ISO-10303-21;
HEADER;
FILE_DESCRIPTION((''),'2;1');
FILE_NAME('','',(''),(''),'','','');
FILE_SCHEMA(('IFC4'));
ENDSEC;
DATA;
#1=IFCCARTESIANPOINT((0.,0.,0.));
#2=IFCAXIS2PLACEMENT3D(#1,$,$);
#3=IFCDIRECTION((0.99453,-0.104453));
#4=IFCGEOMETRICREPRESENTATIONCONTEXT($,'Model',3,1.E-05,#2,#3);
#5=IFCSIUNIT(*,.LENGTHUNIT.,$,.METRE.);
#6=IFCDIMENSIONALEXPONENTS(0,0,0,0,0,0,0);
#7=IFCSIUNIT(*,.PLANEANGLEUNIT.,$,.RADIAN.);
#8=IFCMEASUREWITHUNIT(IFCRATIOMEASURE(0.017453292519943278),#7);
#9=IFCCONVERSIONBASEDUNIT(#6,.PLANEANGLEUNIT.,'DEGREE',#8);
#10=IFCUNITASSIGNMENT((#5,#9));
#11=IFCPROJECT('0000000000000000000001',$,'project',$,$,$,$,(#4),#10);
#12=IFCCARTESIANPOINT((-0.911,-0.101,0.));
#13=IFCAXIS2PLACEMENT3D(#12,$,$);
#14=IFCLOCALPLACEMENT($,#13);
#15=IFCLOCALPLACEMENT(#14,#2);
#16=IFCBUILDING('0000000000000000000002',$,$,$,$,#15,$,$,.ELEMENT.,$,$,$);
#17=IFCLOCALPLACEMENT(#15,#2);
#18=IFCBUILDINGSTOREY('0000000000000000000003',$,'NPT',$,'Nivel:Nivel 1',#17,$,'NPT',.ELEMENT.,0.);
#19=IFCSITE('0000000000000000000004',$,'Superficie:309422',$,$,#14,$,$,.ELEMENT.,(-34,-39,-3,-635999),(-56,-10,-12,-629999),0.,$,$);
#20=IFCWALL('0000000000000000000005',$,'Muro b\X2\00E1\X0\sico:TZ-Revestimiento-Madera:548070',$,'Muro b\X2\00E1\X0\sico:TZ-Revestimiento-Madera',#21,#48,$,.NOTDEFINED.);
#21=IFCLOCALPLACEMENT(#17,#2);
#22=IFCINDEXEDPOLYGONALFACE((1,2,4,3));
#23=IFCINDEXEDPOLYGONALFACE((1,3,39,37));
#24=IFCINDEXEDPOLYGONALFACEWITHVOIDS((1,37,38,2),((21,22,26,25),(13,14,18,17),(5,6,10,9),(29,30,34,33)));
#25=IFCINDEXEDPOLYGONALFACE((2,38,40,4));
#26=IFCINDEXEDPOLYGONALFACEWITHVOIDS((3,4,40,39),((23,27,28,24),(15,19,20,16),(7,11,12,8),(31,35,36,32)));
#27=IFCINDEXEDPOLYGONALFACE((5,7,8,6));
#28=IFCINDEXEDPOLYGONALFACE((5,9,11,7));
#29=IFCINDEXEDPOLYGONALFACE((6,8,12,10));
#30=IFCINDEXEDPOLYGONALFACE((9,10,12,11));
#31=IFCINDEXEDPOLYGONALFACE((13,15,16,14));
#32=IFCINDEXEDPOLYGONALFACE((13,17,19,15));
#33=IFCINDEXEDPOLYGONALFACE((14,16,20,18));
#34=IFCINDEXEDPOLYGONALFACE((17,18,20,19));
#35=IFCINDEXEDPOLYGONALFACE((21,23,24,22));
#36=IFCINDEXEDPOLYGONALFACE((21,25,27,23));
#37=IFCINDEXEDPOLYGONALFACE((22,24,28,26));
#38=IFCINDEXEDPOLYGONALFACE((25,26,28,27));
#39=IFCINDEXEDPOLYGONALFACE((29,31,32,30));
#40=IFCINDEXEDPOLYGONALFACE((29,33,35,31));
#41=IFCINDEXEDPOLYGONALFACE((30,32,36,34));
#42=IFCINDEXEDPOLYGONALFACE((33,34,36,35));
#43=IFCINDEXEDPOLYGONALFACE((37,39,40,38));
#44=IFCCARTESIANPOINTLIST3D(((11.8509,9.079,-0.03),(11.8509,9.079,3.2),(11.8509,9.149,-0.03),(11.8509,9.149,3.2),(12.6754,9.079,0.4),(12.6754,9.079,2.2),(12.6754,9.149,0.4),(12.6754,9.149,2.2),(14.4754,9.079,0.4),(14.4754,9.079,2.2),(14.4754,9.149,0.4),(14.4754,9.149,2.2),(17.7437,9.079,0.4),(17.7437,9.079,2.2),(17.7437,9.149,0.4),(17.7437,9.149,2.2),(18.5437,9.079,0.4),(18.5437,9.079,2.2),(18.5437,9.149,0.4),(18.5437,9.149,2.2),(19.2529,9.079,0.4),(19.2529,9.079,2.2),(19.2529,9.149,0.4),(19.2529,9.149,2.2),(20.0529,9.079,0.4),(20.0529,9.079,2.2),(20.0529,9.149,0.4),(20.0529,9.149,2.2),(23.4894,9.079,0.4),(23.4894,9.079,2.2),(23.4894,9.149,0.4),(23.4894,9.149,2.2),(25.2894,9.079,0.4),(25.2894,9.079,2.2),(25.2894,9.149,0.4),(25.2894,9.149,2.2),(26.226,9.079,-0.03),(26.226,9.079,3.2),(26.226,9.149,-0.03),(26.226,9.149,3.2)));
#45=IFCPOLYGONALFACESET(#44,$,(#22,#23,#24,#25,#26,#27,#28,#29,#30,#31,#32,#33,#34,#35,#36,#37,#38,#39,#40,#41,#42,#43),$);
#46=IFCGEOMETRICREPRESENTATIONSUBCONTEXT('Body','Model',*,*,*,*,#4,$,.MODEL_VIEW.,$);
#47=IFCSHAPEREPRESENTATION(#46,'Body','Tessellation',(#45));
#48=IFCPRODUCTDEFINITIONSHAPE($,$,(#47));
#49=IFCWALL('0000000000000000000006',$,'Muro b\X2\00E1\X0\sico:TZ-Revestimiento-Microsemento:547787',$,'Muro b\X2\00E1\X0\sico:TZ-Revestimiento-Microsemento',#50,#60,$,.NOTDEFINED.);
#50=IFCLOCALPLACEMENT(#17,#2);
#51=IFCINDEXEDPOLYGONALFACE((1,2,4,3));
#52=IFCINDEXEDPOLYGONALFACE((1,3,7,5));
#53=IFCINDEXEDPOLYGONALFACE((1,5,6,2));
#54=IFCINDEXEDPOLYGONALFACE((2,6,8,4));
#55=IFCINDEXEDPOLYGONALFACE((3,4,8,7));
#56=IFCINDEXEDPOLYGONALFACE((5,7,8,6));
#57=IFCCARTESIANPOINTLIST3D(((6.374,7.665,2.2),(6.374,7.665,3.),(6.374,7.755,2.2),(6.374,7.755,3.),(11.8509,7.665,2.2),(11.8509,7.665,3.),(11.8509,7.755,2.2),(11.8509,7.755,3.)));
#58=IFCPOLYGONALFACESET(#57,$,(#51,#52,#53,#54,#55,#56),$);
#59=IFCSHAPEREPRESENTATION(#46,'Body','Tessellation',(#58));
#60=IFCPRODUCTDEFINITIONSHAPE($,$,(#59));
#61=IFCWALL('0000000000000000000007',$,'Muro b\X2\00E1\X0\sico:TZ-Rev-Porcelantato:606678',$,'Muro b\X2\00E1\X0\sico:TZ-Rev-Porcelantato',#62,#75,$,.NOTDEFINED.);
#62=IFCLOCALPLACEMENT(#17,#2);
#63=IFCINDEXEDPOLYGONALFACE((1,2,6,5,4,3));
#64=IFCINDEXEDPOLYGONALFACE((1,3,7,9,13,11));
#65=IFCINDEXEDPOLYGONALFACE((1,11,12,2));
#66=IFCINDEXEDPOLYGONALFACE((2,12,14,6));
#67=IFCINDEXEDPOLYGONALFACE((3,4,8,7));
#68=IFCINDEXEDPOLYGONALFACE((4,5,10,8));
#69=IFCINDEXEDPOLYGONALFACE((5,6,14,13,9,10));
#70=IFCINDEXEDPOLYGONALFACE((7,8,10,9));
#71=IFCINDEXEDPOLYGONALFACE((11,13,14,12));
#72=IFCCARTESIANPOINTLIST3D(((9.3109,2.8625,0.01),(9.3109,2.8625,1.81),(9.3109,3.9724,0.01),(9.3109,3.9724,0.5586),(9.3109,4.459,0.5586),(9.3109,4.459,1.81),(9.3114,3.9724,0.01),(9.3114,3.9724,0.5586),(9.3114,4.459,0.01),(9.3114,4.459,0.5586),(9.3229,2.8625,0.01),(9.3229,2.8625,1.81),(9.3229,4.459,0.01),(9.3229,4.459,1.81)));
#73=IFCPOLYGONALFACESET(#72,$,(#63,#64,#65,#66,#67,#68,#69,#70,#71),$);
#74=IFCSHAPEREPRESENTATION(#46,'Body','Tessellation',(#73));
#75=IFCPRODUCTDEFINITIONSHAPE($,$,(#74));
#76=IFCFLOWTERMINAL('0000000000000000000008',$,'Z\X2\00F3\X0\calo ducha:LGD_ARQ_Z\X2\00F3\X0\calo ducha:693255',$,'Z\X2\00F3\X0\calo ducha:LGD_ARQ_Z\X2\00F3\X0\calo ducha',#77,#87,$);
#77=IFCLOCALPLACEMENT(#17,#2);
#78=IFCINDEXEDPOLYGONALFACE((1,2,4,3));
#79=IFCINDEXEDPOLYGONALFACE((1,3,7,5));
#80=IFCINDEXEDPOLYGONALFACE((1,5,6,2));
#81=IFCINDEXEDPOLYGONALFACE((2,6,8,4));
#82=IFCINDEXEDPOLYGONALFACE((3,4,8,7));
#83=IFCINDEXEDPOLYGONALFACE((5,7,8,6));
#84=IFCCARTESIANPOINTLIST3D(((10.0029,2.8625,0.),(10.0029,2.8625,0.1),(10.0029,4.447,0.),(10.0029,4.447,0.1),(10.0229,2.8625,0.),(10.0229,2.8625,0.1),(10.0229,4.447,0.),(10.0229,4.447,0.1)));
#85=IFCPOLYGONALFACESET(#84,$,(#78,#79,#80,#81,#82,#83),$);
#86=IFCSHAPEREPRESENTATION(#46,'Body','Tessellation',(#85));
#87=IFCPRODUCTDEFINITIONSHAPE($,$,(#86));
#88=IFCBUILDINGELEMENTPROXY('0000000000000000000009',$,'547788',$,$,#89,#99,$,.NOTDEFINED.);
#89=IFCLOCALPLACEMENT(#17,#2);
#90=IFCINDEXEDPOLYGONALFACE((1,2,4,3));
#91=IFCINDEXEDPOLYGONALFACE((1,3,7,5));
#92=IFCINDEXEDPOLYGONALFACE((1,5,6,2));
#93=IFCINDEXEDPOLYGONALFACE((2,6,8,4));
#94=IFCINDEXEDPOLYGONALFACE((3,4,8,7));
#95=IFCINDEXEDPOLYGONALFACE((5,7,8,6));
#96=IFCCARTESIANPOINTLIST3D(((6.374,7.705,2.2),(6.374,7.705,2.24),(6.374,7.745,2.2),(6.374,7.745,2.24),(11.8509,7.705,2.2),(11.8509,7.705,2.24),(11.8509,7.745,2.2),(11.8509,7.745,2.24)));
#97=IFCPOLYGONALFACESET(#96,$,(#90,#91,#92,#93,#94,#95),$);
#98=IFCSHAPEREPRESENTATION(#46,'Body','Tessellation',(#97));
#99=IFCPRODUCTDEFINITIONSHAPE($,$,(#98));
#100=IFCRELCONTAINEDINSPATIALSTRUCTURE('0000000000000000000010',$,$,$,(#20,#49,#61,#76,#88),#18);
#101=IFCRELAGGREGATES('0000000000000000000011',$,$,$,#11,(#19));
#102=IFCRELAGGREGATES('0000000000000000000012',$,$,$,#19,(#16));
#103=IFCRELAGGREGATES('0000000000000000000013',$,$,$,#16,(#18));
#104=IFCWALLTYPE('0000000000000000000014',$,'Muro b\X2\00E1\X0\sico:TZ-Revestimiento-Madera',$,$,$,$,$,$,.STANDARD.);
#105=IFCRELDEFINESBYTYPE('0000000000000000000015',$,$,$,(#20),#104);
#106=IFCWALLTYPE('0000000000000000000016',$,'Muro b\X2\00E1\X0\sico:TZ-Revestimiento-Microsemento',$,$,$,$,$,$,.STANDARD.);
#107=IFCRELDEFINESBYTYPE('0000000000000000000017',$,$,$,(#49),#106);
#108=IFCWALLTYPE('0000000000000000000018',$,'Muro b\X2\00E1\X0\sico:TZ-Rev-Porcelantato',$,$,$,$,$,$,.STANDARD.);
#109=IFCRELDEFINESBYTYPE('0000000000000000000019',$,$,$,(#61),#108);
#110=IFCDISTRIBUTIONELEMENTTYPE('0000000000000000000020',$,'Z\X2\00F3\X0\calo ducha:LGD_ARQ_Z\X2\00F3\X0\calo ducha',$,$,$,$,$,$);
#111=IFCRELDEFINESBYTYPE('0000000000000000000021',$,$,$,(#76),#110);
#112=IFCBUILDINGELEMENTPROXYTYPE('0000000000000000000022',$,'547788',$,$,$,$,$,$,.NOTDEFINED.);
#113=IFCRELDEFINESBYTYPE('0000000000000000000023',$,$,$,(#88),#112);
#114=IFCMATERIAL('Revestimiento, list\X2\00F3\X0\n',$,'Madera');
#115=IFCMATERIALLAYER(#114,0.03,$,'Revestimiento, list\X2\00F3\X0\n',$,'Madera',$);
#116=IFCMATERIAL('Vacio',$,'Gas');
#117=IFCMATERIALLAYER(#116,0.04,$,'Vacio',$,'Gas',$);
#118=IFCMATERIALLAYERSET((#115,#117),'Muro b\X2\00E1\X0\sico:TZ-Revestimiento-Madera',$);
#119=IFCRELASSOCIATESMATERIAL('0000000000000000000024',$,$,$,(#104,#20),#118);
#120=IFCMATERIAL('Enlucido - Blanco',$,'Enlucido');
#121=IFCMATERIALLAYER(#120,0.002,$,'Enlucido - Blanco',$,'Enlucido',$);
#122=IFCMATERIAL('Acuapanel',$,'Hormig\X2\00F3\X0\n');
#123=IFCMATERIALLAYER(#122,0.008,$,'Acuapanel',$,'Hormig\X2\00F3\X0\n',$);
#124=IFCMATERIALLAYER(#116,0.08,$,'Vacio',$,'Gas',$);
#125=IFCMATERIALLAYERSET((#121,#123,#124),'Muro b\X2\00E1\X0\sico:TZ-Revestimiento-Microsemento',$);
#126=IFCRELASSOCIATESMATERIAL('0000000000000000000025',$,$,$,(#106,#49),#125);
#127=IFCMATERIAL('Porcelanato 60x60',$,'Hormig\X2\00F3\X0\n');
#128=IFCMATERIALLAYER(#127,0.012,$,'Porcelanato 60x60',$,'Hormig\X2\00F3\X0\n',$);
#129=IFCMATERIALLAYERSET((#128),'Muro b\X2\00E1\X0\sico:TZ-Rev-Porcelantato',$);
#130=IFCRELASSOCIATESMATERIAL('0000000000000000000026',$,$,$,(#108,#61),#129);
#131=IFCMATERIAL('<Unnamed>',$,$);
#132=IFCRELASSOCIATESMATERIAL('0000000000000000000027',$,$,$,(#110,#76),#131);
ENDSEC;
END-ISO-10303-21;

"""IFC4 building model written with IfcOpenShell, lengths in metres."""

from ifc_helpers import new_model, entity, si_unit, converted_unit, direction, frame, frame_2d, origin, origin_2d_with_axis, place, context, subcontext, project, spatial, polyline, rectangle, extrude, clip, bounded_halfspace, source, transform, mapped, material, layer, layer_set, layer_usage, type_object, type_shapes, element, save


model = new_model("IFC4")

# Units and contexts
model_context = context("Model", 3, precision=1e-05, world=origin(), true_north=direction((0.99453, -0.104453)))
body_context = subcontext(model_context, "Body", "Model", "MODEL_VIEW")
ifc_project = project(units=[si_unit("LENGTHUNIT", "METRE"), converted_unit("PLANEANGLEUNIT", "DEGREE", entity("IfcRatioMeasure", 0.017453292519943278), si_unit("PLANEANGLEUNIT", "RADIAN"), dimensions=[0, 0, 0, 0, 0, 0, 0])], contexts=[model_context])

# Site, building, storey
site_placement = place(None, frame((-0.911, -0.101, 0.0)))
site = spatial("IfcSite", under=ifc_project, at=site_placement, Name="Superficie:309422", CompositionType="ELEMENT", RefLatitude=(-34, -39, -3, -635999), RefLongitude=(-56, -10, -12, -629999), RefElevation=0.0)
building_placement = place(site_placement, origin())
building = spatial("IfcBuilding", under=site, at=building_placement, CompositionType="ELEMENT")
storey_placement = place(building_placement, origin())
storey = spatial("IfcBuildingStorey", under=building, at=storey_placement, Name="NPT", ObjectType="Nivel:Nivel 1", LongName="NPT", CompositionType="ELEMENT", Elevation=0.0)

# Shared definitions
ifc_material_1 = material(Name="<Unnamed>")

# Wall, openings
ifc_material_2 = material(Name="Revestimiento, listón", Category="Madera")
ifc_layer_1 = layer(ifc_material_2, 0.03, Name="Revestimiento, listón", Category="Madera")
ifc_material_3 = material(Name="Vacio", Category="Gas")
ifc_layer_2 = layer(ifc_material_3, 0.04, Name="Vacio", Category="Gas")
ifc_layer_set_1 = layer_set([ifc_layer_1, ifc_layer_2], Name="Muro básico:TZ-Revestimiento-Madera")
ifc_layer_usage_1 = layer_usage(ifc_layer_set_1, "AXIS2", "NEGATIVE", 0.035)
wall_type_1 = type_object("IfcWallType", Name="Muro básico:TZ-Revestimiento-Madera", PredefinedType="STANDARD", material=ifc_layer_set_1)
wall_1_placement = place(storey_placement, frame((11.8509, 9.114, -0.03)))
wall_1 = element("IfcWall", 1, at=wall_1_placement, inside=storey, type_object=wall_type_1, material=ifc_layer_usage_1, Name="Muro básico:TZ-Revestimiento-Madera:548070", ObjectType="Muro básico:TZ-Revestimiento-Madera", PredefinedType="NOTDEFINED", context=body_context, shape_type="SweptSolid", body=[
    extrude(rectangle(XDim=14.375, YDim=0.07, at=frame_2d((7.1875, 0.0), x_axis=(1.0, 0.0))), origin(), (0.0, 0.0, 1.0), 3.23),
])
opening_1_placement = place(wall_1_placement, frame((5.8928, -1.676, 0.43)))
element("IfcOpeningElement", 2, at=opening_1_placement, cuts=wall_1, PredefinedType="OPENING", context=body_context, shape_type="SweptSolid", body=[
    extrude(rectangle(XDim=1.8, YDim=0.8, at=frame_2d((0.0, 0.0), x_axis=(1.0, 0.0))), frame((0.4, 0.0, 0.9), z_axis=(0.0, 1.0, 0.0), x_axis=(0.0, 0.0, 1.0)), (0.0, 0.0, 1.0), 3.048),
])
opening_2_placement = place(wall_1_placement, frame((0.8245, -1.676, 0.43)))
element("IfcOpeningElement", 3, at=opening_2_placement, cuts=wall_1, PredefinedType="OPENING", context=body_context, shape_type="SweptSolid", body=[
    extrude(rectangle(XDim=1.8, YDim=1.8, at=origin_2d_with_axis()), frame((0.9, 0.0, 0.9), z_axis=(0.0, 1.0, 0.0), x_axis=(0.0, 0.0, 1.0)), (0.0, 0.0, 1.0), 3.048),
])
opening_3_placement = place(wall_1_placement, frame((11.6385, -1.676, 0.43)))
element("IfcOpeningElement", 4, at=opening_3_placement, cuts=wall_1, PredefinedType="OPENING", context=body_context, shape_type="SweptSolid", body=[
    extrude(rectangle(XDim=1.8, YDim=1.8, at=frame_2d((0.0, 0.0), x_axis=(0.0, 1.0))), frame((0.9, 0.0, 0.9), z_axis=(0.0, 1.0, 0.0), x_axis=(-1.0, 0.0, 0.0)), (0.0, 0.0, 1.0), 3.048),
])
opening_4_placement = place(wall_1_placement, frame((7.402, -1.676, 0.43)))
element("IfcOpeningElement", 5, at=opening_4_placement, cuts=wall_1, PredefinedType="OPENING", context=body_context, shape_type="SweptSolid", body=[
    extrude(rectangle(XDim=1.8, YDim=0.8, at=frame_2d((0.0, 0.0), x_axis=(1.0, 0.0))), frame((0.4, 0.0, 0.9), z_axis=(0.0, 1.0, 0.0), x_axis=(0.0, 0.0, 1.0)), (0.0, 0.0, 1.0), 3.048),
])

# Wall
ifc_material_4 = material(Name="Enlucido - Blanco", Category="Enlucido")
ifc_layer_3 = layer(ifc_material_4, 0.002, Name="Enlucido - Blanco", Category="Enlucido")
ifc_material_5 = material(Name="Acuapanel", Category="Hormigón")
ifc_layer_4 = layer(ifc_material_5, 0.008, Name="Acuapanel", Category="Hormigón")
ifc_layer_5 = layer(ifc_material_3, 0.08, Name="Vacio", Category="Gas")
ifc_layer_set_2 = layer_set([ifc_layer_3, ifc_layer_4, ifc_layer_5], Name="Muro básico:TZ-Revestimiento-Microsemento")
ifc_layer_usage_2 = layer_usage(ifc_layer_set_2, "AXIS2", "NEGATIVE", 0.045)
wall_type_2 = type_object("IfcWallType", Name="Muro básico:TZ-Revestimiento-Microsemento", PredefinedType="STANDARD", material=ifc_layer_set_2)
wall_2_placement = place(storey_placement, frame((6.374, 7.71, 2.2)))
element("IfcWall", 6, at=wall_2_placement, inside=storey, type_object=wall_type_2, material=ifc_layer_usage_2, Name="Muro básico:TZ-Revestimiento-Microsemento:547787", ObjectType="Muro básico:TZ-Revestimiento-Microsemento", PredefinedType="NOTDEFINED", context=body_context, shape_type="SweptSolid", body=[
    extrude(rectangle(XDim=5.4769, YDim=0.09, at=frame_2d((2.7385, 0.0), x_axis=(-1.0, 0.0))), origin(), (0.0, 0.0, 1.0), 0.8),
])

# Wall
ifc_material_6 = material(Name="Porcelanato 60x60", Category="Hormigón")
ifc_layer_6 = layer(ifc_material_6, 0.012, Name="Porcelanato 60x60", Category="Hormigón")
ifc_layer_set_3 = layer_set([ifc_layer_6], Name="Muro básico:TZ-Rev-Porcelantato")
ifc_layer_usage_3 = layer_usage(ifc_layer_set_3, "AXIS2", "POSITIVE", -0.006)
wall_type_3 = type_object("IfcWallType", Name="Muro básico:TZ-Rev-Porcelantato", PredefinedType="STANDARD", material=ifc_layer_set_3)
wall_3_placement = place(storey_placement, frame((9.3169, 4.459, 0.01), z_axis=(0.0, 0.0, 1.0), x_axis=(0.0, -1.0, 0.0)))
element("IfcWall", 7, at=wall_3_placement, inside=storey, type_object=wall_type_3, material=ifc_layer_usage_3, Name="Muro básico:TZ-Rev-Porcelantato:606678", ObjectType="Muro básico:TZ-Rev-Porcelantato", PredefinedType="NOTDEFINED", context=body_context, shape_type="Clipping", body=[
    clip(extrude(rectangle(XDim=1.5965, YDim=0.012, at=frame_2d((0.7982, 0.0), x_axis=(-1.0, 0.0))), origin(), (0.0, 0.0, 1.0), 1.8), bounded_halfspace(frame((0.0, -0.0055, 0.0), z_axis=(0.0, 1.0, 0.0), x_axis=(-1.0, 0.0, 0.0)), True, frame((0.0, -0.0055, 0.0), z_axis=(0.0, 1.0, 0.0), x_axis=(-1.0, 0.0, 0.0)), polyline([(0.0, 0.0), (0.0, 0.5486), (-0.4866, 0.5486), (-0.4866, 0.0), (0.0, 0.0)]))),
])

# Flow terminal
distribution_element_type = type_object("IfcDistributionElementType", Name="Zócalo ducha:LGD_ARQ_Zócalo ducha", material=ifc_material_1)
shared_shape_1 = source(origin(), body_context, "Body", "SweptSolid", [
    extrude(rectangle(XDim=1.5845, YDim=0.02, at=frame_2d((0.0, 0.0), x_axis=(1.0, 0.0))), frame((0.0, 0.0, 0.0), z_axis=(0.0, 0.0, 1.0), x_axis=(-1.0, 0.0, 0.0)), (0.0, 0.0, 1.0), 0.1),
])
type_shapes(distribution_element_type, [shared_shape_1])
flow_terminal_placement = place(storey_placement, frame((10.0129, 3.6548, 0.0), z_axis=(0.0, 0.0, 1.0), x_axis=(0.0, 1.0, 0.0)))
element("IfcFlowTerminal", 8, at=flow_terminal_placement, inside=storey, type_object=distribution_element_type, material=ifc_material_1, Name="Zócalo ducha:LGD_ARQ_Zócalo ducha:693255", ObjectType="Zócalo ducha:LGD_ARQ_Zócalo ducha", context=body_context, shape_type="MappedRepresentation", body=[
    mapped(shared_shape_1, transform((0.0, 0.0, 0.0), scale=1.0)),
])

# Building element proxy
building_element_proxy_type = type_object("IfcBuildingElementProxyType", Name="547788", PredefinedType="NOTDEFINED")
proxy_placement = place(storey_placement, frame((6.374, 7.705, 2.2)))
element("IfcBuildingElementProxy", 9, at=proxy_placement, inside=storey, type_object=building_element_proxy_type, Name="547788", PredefinedType="NOTDEFINED", context=body_context, shape_type="SweptSolid", body=[
    extrude(rectangle(XDim=5.4769, YDim=0.04, at=frame_2d((0.0, 0.0), x_axis=(1.0, 0.0))), frame((2.7385, 0.02, 0.0)), (0.0, 0.0, 1.0), 0.04),
])

save(model, "model.ifc")
